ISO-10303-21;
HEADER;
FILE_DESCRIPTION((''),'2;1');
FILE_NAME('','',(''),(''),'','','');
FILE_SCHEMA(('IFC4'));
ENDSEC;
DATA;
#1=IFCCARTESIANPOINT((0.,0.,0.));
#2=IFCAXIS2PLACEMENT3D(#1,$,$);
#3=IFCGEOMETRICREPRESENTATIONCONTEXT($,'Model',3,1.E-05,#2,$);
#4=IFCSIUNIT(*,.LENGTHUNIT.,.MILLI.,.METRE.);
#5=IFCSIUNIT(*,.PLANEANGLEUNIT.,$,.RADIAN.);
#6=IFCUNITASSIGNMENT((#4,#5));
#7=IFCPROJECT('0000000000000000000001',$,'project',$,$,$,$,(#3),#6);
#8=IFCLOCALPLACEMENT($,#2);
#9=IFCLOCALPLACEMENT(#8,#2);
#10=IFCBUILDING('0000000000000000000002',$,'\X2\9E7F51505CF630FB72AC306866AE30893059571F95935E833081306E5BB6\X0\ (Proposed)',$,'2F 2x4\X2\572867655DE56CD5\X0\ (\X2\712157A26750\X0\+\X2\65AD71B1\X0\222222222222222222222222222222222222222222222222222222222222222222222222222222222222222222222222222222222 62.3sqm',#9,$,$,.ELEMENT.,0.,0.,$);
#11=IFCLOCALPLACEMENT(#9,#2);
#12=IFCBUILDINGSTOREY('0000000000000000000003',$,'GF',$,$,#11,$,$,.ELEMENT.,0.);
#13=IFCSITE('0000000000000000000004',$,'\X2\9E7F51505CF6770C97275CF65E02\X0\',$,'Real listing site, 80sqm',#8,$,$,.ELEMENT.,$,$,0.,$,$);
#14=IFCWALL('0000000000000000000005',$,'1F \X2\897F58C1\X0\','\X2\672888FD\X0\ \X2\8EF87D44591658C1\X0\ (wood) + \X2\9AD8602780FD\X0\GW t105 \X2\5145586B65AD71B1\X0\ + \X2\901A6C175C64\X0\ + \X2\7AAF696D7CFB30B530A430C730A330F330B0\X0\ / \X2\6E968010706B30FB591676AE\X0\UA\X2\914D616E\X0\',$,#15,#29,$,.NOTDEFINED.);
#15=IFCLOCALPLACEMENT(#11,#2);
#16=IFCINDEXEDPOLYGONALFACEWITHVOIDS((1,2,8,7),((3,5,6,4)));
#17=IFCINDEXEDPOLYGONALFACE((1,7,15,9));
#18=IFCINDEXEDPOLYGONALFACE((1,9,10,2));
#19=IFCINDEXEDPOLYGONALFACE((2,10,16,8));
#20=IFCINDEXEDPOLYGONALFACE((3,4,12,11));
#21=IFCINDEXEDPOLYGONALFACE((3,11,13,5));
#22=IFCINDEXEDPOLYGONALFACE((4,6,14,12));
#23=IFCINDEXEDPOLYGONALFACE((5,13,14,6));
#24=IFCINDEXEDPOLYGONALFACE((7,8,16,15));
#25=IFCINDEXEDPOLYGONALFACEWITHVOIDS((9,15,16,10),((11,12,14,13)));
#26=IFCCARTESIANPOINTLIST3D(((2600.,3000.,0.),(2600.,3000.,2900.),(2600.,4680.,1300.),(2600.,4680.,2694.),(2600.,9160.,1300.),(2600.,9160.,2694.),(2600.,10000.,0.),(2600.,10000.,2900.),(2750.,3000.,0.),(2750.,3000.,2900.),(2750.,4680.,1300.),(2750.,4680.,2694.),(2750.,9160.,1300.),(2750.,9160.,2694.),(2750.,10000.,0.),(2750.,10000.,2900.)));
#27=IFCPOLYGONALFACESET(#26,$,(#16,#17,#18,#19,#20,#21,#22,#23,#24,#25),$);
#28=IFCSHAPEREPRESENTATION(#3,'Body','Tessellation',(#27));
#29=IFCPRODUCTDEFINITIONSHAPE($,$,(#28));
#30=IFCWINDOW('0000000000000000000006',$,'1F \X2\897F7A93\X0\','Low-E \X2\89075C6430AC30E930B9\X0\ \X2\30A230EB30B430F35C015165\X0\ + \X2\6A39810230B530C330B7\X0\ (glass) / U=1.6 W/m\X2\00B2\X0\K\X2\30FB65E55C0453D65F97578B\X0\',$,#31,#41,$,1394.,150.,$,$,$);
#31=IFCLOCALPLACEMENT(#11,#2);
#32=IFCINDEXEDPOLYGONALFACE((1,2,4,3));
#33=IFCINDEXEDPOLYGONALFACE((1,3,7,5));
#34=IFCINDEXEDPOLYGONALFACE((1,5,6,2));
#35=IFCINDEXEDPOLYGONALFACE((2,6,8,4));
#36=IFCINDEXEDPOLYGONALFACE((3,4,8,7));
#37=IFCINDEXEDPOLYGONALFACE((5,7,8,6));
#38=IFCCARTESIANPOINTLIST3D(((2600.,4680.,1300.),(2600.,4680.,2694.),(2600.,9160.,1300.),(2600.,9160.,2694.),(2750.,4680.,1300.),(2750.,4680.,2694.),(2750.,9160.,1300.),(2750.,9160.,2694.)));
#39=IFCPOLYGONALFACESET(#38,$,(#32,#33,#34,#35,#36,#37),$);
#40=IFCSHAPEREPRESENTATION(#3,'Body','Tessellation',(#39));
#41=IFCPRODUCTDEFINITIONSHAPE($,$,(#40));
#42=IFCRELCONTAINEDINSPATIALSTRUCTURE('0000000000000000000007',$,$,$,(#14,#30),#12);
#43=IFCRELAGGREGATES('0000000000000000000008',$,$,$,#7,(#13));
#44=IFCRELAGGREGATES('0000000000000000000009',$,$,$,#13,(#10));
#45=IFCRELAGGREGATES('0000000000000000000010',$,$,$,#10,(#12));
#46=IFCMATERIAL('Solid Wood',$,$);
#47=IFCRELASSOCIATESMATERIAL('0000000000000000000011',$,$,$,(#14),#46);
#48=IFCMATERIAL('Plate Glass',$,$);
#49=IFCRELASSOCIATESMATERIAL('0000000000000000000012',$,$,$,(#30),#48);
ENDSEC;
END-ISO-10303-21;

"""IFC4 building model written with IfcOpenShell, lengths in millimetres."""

from ifc_helpers import new_model, si_unit, frame, frame_2d, origin, place, context, project, spatial, rectangle, extrude, material, element, fill, save


model = new_model("IFC4")

# Units and contexts
model_context = context("Model", 3, precision=1e-05, world=origin())
ifc_project = project(units=[si_unit("LENGTHUNIT", "METRE", prefix="MILLI"), si_unit("PLANEANGLEUNIT", "RADIAN")], contexts=[model_context])

# Site, building, storey
site_placement = place(None, origin())
site = spatial("IfcSite", under=ifc_project, at=site_placement, Name="鹿児島県霧島市", ObjectType="Real listing site, 80sqm", CompositionType="ELEMENT", RefElevation=0.0)
building_placement = place(site_placement, origin())
building = spatial("IfcBuilding", under=site, at=building_placement, Name="鹿児島・犬と暮らす土間広めの家 (Proposed)", ObjectType="2F 2x4在来工法 (無垢材+断熱222222222222222222222222222222222222222222222222222222222222222222222222222222222222222222222222222222222 62.3sqm", CompositionType="ELEMENT", ElevationOfRefHeight=0.0, ElevationOfTerrain=0.0)
storey_placement = place(building_placement, origin())
storey = spatial("IfcBuildingStorey", under=building, at=storey_placement, Name="GF", CompositionType="ELEMENT", Elevation=0.0)

# Shared definitions
ifc_material_1 = material(Name="Solid Wood")

# Shared definitions
ifc_material_2 = material(Name="Plate Glass")

# Wall, opening, window
wall_1_placement = place(storey_placement, frame((1300.0, 1500.0, 0.0)))
wall_1 = element("IfcWall", 1, at=wall_1_placement, inside=storey, material=ifc_material_1, Name="1F 西壁", Description="木製 軸組外壁 (wood) + 高性能GW t105 充填断熱 + 通気層 + 窯業系サイディング / 準耐火・外皮UA配慮", PredefinedType="NOTDEFINED", context=model_context, shape_type="SweptSolid", body=[
    extrude(rectangle(XDim=150.0, YDim=7000.0, at=frame_2d((75.0, 3500.0))), frame((1300.0, 1500.0, 0.0)), (0.0, 0.0, 1.0), 2900.0),
])
opening_1_placement = place(storey_placement, frame((1300.0, 2340.0, 650.0)))
opening_1 = element("IfcOpeningElement", 2, at=opening_1_placement, cuts=wall_1, PredefinedType="NOTDEFINED", context=model_context, shape_type="SweptSolid", body=[
    extrude(rectangle(XDim=150.0, YDim=4480.0, at=frame_2d((75.0, 2240.0))), frame((1300.0, 2340.0, 650.0)), (0.0, 0.0, 1.0), 1394.0),
])
window_1_placement = place(storey_placement, frame((1300.0, 2340.0, 650.0)))
window_1 = element("IfcWindow", 3, at=window_1_placement, inside=storey, material=ifc_material_2, Name="1F 西窓", Description="Low-E 複層ガラス アルゴン封入 + 樹脂サッシ (glass) / U=1.6 W/m²K・日射取得型", OverallHeight=1394.0, OverallWidth=150.0, context=model_context, shape_type="SweptSolid", body=[
    extrude(rectangle(XDim=150.0, YDim=4480.0, at=frame_2d((75.0, 2240.0))), frame((1300.0, 2340.0, 650.0)), (0.0, 0.0, 1.0), 1394.0),
])
fill(opening_1, window_1)

save(model, "model.ifc")
